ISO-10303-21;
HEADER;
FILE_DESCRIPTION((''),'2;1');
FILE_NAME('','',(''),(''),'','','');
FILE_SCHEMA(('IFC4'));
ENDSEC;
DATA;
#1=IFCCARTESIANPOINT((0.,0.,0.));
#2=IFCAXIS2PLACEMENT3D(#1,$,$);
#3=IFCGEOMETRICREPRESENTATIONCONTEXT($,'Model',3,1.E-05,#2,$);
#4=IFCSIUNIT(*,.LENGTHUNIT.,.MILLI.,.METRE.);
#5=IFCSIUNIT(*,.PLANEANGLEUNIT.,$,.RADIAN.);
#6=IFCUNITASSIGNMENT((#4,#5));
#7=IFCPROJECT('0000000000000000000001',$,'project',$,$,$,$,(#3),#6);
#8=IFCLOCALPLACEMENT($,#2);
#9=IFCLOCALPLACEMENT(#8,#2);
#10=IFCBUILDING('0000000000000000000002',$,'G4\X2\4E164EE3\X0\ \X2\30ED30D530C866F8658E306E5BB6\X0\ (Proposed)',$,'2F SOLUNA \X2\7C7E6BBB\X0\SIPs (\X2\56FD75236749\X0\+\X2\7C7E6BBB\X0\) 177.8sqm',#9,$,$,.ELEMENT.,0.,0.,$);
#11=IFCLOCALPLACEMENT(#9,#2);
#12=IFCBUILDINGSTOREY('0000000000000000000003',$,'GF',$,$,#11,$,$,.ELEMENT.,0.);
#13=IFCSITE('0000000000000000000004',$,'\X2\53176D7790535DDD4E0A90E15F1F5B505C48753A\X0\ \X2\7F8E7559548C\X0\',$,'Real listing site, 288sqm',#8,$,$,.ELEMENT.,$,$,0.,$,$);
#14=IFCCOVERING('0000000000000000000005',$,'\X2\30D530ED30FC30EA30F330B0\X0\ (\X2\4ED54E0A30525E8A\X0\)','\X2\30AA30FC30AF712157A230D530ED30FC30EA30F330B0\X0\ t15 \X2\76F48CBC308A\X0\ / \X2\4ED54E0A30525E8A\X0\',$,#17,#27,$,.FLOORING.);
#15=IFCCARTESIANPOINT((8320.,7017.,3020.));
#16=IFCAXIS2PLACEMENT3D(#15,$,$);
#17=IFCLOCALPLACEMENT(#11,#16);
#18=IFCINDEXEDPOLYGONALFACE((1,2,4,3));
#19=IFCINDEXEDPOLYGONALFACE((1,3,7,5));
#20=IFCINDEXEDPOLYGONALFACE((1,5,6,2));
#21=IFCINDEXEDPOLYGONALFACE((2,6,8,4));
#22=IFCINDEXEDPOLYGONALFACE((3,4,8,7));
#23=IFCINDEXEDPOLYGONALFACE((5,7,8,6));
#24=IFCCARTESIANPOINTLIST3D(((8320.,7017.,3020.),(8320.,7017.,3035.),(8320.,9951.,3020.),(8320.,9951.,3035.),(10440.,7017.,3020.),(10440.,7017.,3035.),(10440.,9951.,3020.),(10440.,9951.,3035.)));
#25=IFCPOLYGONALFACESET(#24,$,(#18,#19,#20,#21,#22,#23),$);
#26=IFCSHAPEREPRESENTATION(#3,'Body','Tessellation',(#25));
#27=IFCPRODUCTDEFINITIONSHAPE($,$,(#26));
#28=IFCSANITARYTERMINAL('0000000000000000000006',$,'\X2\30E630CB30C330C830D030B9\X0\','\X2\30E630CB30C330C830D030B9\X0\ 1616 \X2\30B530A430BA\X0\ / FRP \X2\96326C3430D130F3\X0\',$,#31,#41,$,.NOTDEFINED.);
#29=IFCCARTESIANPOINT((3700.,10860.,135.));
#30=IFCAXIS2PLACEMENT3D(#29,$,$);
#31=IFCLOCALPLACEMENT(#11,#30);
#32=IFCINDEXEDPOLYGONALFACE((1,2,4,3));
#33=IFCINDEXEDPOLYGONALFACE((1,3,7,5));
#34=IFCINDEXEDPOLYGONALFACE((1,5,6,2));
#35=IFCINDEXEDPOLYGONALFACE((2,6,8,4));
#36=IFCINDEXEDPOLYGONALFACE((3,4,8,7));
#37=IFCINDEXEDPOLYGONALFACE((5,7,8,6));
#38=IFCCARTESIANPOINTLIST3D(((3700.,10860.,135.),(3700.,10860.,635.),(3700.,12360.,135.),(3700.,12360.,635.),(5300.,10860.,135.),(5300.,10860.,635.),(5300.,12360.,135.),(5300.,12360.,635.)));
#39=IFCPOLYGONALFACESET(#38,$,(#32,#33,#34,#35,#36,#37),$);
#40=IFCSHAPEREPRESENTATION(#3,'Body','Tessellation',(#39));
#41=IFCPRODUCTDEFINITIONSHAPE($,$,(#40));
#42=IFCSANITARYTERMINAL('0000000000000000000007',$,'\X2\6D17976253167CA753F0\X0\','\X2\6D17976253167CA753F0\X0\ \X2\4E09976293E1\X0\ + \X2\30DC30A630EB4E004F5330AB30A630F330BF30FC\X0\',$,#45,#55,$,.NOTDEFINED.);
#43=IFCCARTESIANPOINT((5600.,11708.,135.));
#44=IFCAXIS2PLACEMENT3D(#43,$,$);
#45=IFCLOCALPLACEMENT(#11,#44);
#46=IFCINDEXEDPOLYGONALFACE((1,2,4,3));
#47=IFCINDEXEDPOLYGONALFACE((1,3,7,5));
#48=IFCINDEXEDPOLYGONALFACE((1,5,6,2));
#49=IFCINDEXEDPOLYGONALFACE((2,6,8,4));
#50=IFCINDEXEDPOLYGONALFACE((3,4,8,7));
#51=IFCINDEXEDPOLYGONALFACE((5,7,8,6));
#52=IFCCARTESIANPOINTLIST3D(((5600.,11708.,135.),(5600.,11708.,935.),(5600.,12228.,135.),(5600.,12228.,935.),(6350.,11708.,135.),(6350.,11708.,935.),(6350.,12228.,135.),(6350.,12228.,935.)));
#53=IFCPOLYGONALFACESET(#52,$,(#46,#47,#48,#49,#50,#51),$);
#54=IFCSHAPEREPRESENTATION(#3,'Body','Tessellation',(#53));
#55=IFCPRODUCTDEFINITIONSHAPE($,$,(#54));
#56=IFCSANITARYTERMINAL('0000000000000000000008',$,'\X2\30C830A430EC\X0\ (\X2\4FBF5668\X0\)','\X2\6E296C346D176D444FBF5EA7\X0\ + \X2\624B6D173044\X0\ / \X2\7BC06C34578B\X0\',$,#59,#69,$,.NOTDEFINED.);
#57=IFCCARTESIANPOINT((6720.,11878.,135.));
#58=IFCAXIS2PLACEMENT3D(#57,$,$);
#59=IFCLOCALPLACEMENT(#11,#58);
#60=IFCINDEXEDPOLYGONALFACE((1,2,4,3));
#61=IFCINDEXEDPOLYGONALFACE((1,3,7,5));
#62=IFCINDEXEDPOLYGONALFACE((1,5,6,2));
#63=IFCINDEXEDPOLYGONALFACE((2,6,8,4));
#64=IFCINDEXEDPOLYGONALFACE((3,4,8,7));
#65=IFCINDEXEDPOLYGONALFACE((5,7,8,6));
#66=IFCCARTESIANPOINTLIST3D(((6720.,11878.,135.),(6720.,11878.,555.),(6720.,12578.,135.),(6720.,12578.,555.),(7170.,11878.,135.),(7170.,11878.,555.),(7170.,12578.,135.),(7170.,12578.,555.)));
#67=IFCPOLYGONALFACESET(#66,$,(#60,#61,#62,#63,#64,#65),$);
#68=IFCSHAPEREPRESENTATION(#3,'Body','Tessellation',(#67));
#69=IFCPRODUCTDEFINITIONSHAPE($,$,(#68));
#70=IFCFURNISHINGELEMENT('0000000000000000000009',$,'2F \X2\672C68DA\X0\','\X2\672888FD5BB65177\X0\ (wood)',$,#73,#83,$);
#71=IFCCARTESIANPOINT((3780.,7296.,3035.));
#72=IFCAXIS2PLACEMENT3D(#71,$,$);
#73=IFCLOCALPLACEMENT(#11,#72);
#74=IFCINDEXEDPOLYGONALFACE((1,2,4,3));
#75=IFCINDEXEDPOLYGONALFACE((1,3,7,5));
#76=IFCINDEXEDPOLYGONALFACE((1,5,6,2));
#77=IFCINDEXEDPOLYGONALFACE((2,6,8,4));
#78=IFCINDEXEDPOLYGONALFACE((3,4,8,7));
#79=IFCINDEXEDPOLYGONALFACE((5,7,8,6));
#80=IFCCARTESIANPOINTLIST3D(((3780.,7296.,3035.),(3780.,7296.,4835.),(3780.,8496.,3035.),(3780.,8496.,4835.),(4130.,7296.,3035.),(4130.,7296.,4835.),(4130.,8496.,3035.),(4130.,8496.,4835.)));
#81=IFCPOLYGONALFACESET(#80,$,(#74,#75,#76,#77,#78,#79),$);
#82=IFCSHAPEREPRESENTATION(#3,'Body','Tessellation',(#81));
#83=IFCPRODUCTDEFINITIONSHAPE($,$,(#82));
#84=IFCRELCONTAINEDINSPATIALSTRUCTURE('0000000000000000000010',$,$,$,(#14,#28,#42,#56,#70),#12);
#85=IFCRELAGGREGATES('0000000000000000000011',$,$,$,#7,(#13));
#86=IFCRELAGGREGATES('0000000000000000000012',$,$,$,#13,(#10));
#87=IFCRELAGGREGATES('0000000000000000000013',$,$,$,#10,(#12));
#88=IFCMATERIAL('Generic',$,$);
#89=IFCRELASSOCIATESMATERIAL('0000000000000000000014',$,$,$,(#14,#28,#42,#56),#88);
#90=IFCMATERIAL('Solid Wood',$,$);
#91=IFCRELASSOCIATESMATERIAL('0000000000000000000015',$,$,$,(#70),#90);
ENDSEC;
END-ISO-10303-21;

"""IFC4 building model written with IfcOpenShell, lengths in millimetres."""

from ifc_helpers import new_model, si_unit, frame, frame_2d, origin, place, context, project, spatial, rectangle, extrude, material, element, save


model = new_model("IFC4")

# Units and contexts
model_context = context("Model", 3, precision=1e-05, world=origin())
ifc_project = project(units=[si_unit("LENGTHUNIT", "METRE", prefix="MILLI"), si_unit("PLANEANGLEUNIT", "RADIAN")], contexts=[model_context])

# Site, building, storey
site_placement = place(None, origin())
site = spatial("IfcSite", under=ifc_project, at=site_placement, Name="北海道川上郡弟子屈町 美留和", ObjectType="Real listing site, 288sqm", CompositionType="ELEMENT", RefElevation=0.0)
building_placement = place(site_placement, origin())
building = spatial("IfcBuilding", under=site, at=building_placement, Name="G4世代 ロフト書斎の家 (Proposed)", ObjectType="2F SOLUNA 籾殻SIPs (国産杉+籾殻) 177.8sqm", CompositionType="ELEMENT", ElevationOfRefHeight=0.0, ElevationOfTerrain=0.0)
storey_placement = place(building_placement, origin())
storey = spatial("IfcBuildingStorey", under=building, at=storey_placement, Name="GF", CompositionType="ELEMENT", Elevation=0.0)

# Shared definitions
ifc_material_1 = material(Name="Solid Wood")
ifc_material_2 = material(Name="Generic")

# Covering
covering_1_placement = place(storey_placement, frame((8320.0, 7017.0, 3020.0)))
element("IfcCovering", 1, at=covering_1_placement, inside=storey, material=ifc_material_2, Name="フローリング (仕上げ床)", Description="オーク無垢フローリング t15 直貼り / 仕上げ床", PredefinedType="FLOORING", context=model_context, shape_type="SweptSolid", body=[
    extrude(rectangle(XDim=2120.0, YDim=2934.0, at=frame_2d((1060.0, 1467.0))), frame((8320.0, 7017.0, 3020.0)), (0.0, 0.0, 1.0), 15.0),
])

# Sanitary terminals
sanitary_terminal_1_placement = place(storey_placement, frame((3700.0, 10860.0, 135.0)))
element("IfcSanitaryTerminal", 2, at=sanitary_terminal_1_placement, inside=storey, material=ifc_material_2, Name="ユニットバス", Description="ユニットバス 1616 サイズ / FRP 防水パン", PredefinedType="NOTDEFINED", context=model_context, shape_type="SweptSolid", body=[
    extrude(rectangle(XDim=1600.0, YDim=1500.0, at=frame_2d((800.0, 750.0))), frame((3700.0, 10860.0, 135.0)), (0.0, 0.0, 1.0), 500.0),
])
sanitary_terminal_2_placement = place(storey_placement, frame((5600.0, 11708.0, 135.0)))
element("IfcSanitaryTerminal", 3, at=sanitary_terminal_2_placement, inside=storey, material=ifc_material_2, Name="洗面化粧台", Description="洗面化粧台 三面鏡 + ボウル一体カウンター", PredefinedType="NOTDEFINED", context=model_context, shape_type="SweptSolid", body=[
    extrude(rectangle(XDim=750.0, YDim=520.0, at=frame_2d((375.0, 260.0))), frame((5600.0, 11708.0, 135.0)), (0.0, 0.0, 1.0), 800.0),
])
sanitary_terminal_3_placement = place(storey_placement, frame((6720.0, 11878.0, 135.0)))
element("IfcSanitaryTerminal", 4, at=sanitary_terminal_3_placement, inside=storey, material=ifc_material_2, Name="トイレ (便器)", Description="温水洗浄便座 + 手洗い / 節水型", PredefinedType="NOTDEFINED", context=model_context, shape_type="SweptSolid", body=[
    extrude(rectangle(XDim=450.0, YDim=700.0, at=frame_2d((225.0, 350.0))), frame((6720.0, 11878.0, 135.0)), (0.0, 0.0, 1.0), 420.0),
])

# Furnishing element
furnishing_placement = place(storey_placement, frame((3780.0, 7296.0, 3035.0)))
element("IfcFurnishingElement", 5, at=furnishing_placement, inside=storey, material=ifc_material_1, Name="2F 本棚", Description="木製家具 (wood)", context=model_context, shape_type="SweptSolid", body=[
    extrude(rectangle(XDim=350.0, YDim=1200.0, at=frame_2d((175.0, 600.0))), frame((3780.0, 7296.0, 3035.0)), (0.0, 0.0, 1.0), 1800.0),
])

save(model, "model.ifc")
